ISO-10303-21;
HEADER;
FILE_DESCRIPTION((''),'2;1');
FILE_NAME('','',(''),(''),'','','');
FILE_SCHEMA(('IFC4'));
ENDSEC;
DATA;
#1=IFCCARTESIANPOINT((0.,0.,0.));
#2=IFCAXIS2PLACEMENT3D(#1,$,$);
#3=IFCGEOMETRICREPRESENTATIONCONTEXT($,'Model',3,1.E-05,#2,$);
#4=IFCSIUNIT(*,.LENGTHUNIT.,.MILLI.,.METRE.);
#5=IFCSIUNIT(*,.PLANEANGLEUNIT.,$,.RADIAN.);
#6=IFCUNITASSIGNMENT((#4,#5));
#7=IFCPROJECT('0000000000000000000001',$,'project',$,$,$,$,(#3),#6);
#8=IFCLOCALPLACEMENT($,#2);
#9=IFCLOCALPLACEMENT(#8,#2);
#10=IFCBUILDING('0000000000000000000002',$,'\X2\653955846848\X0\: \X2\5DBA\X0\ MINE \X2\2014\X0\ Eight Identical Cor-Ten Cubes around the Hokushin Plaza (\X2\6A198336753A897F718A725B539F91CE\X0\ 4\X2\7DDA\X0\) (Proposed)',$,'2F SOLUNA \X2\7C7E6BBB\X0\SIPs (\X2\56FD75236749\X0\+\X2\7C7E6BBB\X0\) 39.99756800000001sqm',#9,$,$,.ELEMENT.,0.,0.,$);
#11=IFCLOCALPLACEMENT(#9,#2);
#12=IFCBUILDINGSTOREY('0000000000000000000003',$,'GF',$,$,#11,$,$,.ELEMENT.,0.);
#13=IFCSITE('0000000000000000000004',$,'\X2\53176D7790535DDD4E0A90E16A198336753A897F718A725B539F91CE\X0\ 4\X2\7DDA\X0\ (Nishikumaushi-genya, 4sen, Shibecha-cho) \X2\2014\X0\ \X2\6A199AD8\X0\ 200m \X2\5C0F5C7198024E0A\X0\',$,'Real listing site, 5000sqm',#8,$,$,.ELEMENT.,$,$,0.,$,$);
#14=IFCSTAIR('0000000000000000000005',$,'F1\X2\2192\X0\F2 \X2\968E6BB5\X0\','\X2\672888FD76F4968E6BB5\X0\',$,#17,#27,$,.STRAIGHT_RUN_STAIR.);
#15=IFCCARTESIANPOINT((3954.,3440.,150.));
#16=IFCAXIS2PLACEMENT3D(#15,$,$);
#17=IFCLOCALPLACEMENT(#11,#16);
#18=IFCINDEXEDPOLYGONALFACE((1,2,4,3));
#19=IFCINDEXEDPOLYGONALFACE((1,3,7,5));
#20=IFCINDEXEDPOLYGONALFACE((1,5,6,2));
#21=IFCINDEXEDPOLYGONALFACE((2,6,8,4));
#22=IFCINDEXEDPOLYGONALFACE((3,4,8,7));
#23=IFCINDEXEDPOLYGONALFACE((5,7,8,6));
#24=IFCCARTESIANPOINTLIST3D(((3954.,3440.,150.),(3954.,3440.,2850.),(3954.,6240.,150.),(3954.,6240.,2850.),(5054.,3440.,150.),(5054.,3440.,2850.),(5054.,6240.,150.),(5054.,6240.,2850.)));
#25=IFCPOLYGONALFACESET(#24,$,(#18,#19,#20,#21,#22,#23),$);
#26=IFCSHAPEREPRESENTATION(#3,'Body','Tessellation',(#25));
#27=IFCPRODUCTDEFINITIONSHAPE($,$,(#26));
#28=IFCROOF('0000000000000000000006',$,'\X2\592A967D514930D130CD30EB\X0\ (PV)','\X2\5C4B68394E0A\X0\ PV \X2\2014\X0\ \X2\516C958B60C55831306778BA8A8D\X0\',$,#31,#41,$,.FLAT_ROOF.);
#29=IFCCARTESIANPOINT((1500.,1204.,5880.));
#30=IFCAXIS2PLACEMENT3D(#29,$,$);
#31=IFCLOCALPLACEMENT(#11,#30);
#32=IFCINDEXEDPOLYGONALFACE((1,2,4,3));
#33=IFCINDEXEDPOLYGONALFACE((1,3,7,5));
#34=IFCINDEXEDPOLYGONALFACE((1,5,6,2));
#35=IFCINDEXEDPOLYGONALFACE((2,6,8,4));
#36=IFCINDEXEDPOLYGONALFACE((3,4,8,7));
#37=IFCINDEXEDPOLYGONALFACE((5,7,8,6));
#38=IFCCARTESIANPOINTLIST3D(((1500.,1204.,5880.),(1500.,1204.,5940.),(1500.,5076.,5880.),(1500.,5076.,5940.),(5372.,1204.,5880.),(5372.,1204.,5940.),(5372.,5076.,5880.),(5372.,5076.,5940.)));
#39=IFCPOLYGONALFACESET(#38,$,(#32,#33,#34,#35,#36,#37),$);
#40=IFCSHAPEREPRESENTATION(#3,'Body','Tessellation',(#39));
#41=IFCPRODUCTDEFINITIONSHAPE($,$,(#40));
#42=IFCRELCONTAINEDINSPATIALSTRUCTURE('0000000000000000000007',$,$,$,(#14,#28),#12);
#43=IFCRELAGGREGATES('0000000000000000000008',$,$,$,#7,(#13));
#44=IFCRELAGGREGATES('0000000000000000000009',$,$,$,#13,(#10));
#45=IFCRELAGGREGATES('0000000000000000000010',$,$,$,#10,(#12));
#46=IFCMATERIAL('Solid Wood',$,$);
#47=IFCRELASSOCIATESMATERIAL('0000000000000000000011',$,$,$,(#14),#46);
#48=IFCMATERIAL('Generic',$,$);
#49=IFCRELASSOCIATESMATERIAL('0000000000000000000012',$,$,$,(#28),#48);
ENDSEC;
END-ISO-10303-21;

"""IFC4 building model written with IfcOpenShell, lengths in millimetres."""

from ifc_helpers import new_model, si_unit, frame, frame_2d, origin, place, context, project, spatial, rectangle, extrude, material, element, save


model = new_model("IFC4")

# Units and contexts
model_context = context("Model", 3, precision=1e-05, world=origin())
ifc_project = project(units=[si_unit("LENGTHUNIT", "METRE", prefix="MILLI"), si_unit("PLANEANGLEUNIT", "RADIAN")], contexts=[model_context])

# Site, building, storey
site_placement = place(None, origin())
site = spatial("IfcSite", under=ifc_project, at=site_placement, Name="北海道川上郡標茶町西熊牛原野 4線 (Nishikumaushi-genya, 4sen, Shibecha-cho) — 標高 200m 小山頂上", ObjectType="Real listing site, 5000sqm", CompositionType="ELEMENT", RefElevation=0.0)
building_placement = place(site_placement, origin())
building = spatial("IfcBuilding", under=site, at=building_placement, Name="改善案: 嶺 MINE — Eight Identical Cor-Ten Cubes around the Hokushin Plaza (標茶町西熊牛原野 4線) (Proposed)", ObjectType="2F SOLUNA 籾殻SIPs (国産杉+籾殻) 39.99756800000001sqm", CompositionType="ELEMENT", ElevationOfRefHeight=0.0, ElevationOfTerrain=0.0)
storey_placement = place(building_placement, origin())
storey = spatial("IfcBuildingStorey", under=building, at=storey_placement, Name="GF", CompositionType="ELEMENT", Elevation=0.0)

# Shared definitions
ifc_material_1 = material(Name="Generic")

# Stair
ifc_material_2 = material(Name="Solid Wood")
stair_placement = place(storey_placement, frame((3954.0, 3440.0, 150.0)))
element("IfcStair", 1, at=stair_placement, inside=storey, material=ifc_material_2, Name="F1→F2 階段", Description="木製直階段", PredefinedType="STRAIGHT_RUN_STAIR", context=model_context, shape_type="SweptSolid", body=[
    extrude(rectangle(XDim=1100.0, YDim=2800.0, at=frame_2d((550.0, 1400.0))), frame((3954.0, 3440.0, 150.0)), (0.0, 0.0, 1.0), 2700.0),
])

# Roof
roof_placement = place(storey_placement, frame((1500.0, 1204.0, 5880.0)))
element("IfcRoof", 2, at=roof_placement, inside=storey, material=ifc_material_1, Name="太陽光パネル (PV)", Description="屋根上 PV — 公開情報で確認", PredefinedType="FLAT_ROOF", context=model_context, shape_type="SweptSolid", body=[
    extrude(rectangle(XDim=3872.0, YDim=3872.0, at=frame_2d((1936.0, 1936.0))), frame((1500.0, 1204.0, 5880.0)), (0.0, 0.0, 1.0), 60.0),
])

save(model, "model.ifc")
